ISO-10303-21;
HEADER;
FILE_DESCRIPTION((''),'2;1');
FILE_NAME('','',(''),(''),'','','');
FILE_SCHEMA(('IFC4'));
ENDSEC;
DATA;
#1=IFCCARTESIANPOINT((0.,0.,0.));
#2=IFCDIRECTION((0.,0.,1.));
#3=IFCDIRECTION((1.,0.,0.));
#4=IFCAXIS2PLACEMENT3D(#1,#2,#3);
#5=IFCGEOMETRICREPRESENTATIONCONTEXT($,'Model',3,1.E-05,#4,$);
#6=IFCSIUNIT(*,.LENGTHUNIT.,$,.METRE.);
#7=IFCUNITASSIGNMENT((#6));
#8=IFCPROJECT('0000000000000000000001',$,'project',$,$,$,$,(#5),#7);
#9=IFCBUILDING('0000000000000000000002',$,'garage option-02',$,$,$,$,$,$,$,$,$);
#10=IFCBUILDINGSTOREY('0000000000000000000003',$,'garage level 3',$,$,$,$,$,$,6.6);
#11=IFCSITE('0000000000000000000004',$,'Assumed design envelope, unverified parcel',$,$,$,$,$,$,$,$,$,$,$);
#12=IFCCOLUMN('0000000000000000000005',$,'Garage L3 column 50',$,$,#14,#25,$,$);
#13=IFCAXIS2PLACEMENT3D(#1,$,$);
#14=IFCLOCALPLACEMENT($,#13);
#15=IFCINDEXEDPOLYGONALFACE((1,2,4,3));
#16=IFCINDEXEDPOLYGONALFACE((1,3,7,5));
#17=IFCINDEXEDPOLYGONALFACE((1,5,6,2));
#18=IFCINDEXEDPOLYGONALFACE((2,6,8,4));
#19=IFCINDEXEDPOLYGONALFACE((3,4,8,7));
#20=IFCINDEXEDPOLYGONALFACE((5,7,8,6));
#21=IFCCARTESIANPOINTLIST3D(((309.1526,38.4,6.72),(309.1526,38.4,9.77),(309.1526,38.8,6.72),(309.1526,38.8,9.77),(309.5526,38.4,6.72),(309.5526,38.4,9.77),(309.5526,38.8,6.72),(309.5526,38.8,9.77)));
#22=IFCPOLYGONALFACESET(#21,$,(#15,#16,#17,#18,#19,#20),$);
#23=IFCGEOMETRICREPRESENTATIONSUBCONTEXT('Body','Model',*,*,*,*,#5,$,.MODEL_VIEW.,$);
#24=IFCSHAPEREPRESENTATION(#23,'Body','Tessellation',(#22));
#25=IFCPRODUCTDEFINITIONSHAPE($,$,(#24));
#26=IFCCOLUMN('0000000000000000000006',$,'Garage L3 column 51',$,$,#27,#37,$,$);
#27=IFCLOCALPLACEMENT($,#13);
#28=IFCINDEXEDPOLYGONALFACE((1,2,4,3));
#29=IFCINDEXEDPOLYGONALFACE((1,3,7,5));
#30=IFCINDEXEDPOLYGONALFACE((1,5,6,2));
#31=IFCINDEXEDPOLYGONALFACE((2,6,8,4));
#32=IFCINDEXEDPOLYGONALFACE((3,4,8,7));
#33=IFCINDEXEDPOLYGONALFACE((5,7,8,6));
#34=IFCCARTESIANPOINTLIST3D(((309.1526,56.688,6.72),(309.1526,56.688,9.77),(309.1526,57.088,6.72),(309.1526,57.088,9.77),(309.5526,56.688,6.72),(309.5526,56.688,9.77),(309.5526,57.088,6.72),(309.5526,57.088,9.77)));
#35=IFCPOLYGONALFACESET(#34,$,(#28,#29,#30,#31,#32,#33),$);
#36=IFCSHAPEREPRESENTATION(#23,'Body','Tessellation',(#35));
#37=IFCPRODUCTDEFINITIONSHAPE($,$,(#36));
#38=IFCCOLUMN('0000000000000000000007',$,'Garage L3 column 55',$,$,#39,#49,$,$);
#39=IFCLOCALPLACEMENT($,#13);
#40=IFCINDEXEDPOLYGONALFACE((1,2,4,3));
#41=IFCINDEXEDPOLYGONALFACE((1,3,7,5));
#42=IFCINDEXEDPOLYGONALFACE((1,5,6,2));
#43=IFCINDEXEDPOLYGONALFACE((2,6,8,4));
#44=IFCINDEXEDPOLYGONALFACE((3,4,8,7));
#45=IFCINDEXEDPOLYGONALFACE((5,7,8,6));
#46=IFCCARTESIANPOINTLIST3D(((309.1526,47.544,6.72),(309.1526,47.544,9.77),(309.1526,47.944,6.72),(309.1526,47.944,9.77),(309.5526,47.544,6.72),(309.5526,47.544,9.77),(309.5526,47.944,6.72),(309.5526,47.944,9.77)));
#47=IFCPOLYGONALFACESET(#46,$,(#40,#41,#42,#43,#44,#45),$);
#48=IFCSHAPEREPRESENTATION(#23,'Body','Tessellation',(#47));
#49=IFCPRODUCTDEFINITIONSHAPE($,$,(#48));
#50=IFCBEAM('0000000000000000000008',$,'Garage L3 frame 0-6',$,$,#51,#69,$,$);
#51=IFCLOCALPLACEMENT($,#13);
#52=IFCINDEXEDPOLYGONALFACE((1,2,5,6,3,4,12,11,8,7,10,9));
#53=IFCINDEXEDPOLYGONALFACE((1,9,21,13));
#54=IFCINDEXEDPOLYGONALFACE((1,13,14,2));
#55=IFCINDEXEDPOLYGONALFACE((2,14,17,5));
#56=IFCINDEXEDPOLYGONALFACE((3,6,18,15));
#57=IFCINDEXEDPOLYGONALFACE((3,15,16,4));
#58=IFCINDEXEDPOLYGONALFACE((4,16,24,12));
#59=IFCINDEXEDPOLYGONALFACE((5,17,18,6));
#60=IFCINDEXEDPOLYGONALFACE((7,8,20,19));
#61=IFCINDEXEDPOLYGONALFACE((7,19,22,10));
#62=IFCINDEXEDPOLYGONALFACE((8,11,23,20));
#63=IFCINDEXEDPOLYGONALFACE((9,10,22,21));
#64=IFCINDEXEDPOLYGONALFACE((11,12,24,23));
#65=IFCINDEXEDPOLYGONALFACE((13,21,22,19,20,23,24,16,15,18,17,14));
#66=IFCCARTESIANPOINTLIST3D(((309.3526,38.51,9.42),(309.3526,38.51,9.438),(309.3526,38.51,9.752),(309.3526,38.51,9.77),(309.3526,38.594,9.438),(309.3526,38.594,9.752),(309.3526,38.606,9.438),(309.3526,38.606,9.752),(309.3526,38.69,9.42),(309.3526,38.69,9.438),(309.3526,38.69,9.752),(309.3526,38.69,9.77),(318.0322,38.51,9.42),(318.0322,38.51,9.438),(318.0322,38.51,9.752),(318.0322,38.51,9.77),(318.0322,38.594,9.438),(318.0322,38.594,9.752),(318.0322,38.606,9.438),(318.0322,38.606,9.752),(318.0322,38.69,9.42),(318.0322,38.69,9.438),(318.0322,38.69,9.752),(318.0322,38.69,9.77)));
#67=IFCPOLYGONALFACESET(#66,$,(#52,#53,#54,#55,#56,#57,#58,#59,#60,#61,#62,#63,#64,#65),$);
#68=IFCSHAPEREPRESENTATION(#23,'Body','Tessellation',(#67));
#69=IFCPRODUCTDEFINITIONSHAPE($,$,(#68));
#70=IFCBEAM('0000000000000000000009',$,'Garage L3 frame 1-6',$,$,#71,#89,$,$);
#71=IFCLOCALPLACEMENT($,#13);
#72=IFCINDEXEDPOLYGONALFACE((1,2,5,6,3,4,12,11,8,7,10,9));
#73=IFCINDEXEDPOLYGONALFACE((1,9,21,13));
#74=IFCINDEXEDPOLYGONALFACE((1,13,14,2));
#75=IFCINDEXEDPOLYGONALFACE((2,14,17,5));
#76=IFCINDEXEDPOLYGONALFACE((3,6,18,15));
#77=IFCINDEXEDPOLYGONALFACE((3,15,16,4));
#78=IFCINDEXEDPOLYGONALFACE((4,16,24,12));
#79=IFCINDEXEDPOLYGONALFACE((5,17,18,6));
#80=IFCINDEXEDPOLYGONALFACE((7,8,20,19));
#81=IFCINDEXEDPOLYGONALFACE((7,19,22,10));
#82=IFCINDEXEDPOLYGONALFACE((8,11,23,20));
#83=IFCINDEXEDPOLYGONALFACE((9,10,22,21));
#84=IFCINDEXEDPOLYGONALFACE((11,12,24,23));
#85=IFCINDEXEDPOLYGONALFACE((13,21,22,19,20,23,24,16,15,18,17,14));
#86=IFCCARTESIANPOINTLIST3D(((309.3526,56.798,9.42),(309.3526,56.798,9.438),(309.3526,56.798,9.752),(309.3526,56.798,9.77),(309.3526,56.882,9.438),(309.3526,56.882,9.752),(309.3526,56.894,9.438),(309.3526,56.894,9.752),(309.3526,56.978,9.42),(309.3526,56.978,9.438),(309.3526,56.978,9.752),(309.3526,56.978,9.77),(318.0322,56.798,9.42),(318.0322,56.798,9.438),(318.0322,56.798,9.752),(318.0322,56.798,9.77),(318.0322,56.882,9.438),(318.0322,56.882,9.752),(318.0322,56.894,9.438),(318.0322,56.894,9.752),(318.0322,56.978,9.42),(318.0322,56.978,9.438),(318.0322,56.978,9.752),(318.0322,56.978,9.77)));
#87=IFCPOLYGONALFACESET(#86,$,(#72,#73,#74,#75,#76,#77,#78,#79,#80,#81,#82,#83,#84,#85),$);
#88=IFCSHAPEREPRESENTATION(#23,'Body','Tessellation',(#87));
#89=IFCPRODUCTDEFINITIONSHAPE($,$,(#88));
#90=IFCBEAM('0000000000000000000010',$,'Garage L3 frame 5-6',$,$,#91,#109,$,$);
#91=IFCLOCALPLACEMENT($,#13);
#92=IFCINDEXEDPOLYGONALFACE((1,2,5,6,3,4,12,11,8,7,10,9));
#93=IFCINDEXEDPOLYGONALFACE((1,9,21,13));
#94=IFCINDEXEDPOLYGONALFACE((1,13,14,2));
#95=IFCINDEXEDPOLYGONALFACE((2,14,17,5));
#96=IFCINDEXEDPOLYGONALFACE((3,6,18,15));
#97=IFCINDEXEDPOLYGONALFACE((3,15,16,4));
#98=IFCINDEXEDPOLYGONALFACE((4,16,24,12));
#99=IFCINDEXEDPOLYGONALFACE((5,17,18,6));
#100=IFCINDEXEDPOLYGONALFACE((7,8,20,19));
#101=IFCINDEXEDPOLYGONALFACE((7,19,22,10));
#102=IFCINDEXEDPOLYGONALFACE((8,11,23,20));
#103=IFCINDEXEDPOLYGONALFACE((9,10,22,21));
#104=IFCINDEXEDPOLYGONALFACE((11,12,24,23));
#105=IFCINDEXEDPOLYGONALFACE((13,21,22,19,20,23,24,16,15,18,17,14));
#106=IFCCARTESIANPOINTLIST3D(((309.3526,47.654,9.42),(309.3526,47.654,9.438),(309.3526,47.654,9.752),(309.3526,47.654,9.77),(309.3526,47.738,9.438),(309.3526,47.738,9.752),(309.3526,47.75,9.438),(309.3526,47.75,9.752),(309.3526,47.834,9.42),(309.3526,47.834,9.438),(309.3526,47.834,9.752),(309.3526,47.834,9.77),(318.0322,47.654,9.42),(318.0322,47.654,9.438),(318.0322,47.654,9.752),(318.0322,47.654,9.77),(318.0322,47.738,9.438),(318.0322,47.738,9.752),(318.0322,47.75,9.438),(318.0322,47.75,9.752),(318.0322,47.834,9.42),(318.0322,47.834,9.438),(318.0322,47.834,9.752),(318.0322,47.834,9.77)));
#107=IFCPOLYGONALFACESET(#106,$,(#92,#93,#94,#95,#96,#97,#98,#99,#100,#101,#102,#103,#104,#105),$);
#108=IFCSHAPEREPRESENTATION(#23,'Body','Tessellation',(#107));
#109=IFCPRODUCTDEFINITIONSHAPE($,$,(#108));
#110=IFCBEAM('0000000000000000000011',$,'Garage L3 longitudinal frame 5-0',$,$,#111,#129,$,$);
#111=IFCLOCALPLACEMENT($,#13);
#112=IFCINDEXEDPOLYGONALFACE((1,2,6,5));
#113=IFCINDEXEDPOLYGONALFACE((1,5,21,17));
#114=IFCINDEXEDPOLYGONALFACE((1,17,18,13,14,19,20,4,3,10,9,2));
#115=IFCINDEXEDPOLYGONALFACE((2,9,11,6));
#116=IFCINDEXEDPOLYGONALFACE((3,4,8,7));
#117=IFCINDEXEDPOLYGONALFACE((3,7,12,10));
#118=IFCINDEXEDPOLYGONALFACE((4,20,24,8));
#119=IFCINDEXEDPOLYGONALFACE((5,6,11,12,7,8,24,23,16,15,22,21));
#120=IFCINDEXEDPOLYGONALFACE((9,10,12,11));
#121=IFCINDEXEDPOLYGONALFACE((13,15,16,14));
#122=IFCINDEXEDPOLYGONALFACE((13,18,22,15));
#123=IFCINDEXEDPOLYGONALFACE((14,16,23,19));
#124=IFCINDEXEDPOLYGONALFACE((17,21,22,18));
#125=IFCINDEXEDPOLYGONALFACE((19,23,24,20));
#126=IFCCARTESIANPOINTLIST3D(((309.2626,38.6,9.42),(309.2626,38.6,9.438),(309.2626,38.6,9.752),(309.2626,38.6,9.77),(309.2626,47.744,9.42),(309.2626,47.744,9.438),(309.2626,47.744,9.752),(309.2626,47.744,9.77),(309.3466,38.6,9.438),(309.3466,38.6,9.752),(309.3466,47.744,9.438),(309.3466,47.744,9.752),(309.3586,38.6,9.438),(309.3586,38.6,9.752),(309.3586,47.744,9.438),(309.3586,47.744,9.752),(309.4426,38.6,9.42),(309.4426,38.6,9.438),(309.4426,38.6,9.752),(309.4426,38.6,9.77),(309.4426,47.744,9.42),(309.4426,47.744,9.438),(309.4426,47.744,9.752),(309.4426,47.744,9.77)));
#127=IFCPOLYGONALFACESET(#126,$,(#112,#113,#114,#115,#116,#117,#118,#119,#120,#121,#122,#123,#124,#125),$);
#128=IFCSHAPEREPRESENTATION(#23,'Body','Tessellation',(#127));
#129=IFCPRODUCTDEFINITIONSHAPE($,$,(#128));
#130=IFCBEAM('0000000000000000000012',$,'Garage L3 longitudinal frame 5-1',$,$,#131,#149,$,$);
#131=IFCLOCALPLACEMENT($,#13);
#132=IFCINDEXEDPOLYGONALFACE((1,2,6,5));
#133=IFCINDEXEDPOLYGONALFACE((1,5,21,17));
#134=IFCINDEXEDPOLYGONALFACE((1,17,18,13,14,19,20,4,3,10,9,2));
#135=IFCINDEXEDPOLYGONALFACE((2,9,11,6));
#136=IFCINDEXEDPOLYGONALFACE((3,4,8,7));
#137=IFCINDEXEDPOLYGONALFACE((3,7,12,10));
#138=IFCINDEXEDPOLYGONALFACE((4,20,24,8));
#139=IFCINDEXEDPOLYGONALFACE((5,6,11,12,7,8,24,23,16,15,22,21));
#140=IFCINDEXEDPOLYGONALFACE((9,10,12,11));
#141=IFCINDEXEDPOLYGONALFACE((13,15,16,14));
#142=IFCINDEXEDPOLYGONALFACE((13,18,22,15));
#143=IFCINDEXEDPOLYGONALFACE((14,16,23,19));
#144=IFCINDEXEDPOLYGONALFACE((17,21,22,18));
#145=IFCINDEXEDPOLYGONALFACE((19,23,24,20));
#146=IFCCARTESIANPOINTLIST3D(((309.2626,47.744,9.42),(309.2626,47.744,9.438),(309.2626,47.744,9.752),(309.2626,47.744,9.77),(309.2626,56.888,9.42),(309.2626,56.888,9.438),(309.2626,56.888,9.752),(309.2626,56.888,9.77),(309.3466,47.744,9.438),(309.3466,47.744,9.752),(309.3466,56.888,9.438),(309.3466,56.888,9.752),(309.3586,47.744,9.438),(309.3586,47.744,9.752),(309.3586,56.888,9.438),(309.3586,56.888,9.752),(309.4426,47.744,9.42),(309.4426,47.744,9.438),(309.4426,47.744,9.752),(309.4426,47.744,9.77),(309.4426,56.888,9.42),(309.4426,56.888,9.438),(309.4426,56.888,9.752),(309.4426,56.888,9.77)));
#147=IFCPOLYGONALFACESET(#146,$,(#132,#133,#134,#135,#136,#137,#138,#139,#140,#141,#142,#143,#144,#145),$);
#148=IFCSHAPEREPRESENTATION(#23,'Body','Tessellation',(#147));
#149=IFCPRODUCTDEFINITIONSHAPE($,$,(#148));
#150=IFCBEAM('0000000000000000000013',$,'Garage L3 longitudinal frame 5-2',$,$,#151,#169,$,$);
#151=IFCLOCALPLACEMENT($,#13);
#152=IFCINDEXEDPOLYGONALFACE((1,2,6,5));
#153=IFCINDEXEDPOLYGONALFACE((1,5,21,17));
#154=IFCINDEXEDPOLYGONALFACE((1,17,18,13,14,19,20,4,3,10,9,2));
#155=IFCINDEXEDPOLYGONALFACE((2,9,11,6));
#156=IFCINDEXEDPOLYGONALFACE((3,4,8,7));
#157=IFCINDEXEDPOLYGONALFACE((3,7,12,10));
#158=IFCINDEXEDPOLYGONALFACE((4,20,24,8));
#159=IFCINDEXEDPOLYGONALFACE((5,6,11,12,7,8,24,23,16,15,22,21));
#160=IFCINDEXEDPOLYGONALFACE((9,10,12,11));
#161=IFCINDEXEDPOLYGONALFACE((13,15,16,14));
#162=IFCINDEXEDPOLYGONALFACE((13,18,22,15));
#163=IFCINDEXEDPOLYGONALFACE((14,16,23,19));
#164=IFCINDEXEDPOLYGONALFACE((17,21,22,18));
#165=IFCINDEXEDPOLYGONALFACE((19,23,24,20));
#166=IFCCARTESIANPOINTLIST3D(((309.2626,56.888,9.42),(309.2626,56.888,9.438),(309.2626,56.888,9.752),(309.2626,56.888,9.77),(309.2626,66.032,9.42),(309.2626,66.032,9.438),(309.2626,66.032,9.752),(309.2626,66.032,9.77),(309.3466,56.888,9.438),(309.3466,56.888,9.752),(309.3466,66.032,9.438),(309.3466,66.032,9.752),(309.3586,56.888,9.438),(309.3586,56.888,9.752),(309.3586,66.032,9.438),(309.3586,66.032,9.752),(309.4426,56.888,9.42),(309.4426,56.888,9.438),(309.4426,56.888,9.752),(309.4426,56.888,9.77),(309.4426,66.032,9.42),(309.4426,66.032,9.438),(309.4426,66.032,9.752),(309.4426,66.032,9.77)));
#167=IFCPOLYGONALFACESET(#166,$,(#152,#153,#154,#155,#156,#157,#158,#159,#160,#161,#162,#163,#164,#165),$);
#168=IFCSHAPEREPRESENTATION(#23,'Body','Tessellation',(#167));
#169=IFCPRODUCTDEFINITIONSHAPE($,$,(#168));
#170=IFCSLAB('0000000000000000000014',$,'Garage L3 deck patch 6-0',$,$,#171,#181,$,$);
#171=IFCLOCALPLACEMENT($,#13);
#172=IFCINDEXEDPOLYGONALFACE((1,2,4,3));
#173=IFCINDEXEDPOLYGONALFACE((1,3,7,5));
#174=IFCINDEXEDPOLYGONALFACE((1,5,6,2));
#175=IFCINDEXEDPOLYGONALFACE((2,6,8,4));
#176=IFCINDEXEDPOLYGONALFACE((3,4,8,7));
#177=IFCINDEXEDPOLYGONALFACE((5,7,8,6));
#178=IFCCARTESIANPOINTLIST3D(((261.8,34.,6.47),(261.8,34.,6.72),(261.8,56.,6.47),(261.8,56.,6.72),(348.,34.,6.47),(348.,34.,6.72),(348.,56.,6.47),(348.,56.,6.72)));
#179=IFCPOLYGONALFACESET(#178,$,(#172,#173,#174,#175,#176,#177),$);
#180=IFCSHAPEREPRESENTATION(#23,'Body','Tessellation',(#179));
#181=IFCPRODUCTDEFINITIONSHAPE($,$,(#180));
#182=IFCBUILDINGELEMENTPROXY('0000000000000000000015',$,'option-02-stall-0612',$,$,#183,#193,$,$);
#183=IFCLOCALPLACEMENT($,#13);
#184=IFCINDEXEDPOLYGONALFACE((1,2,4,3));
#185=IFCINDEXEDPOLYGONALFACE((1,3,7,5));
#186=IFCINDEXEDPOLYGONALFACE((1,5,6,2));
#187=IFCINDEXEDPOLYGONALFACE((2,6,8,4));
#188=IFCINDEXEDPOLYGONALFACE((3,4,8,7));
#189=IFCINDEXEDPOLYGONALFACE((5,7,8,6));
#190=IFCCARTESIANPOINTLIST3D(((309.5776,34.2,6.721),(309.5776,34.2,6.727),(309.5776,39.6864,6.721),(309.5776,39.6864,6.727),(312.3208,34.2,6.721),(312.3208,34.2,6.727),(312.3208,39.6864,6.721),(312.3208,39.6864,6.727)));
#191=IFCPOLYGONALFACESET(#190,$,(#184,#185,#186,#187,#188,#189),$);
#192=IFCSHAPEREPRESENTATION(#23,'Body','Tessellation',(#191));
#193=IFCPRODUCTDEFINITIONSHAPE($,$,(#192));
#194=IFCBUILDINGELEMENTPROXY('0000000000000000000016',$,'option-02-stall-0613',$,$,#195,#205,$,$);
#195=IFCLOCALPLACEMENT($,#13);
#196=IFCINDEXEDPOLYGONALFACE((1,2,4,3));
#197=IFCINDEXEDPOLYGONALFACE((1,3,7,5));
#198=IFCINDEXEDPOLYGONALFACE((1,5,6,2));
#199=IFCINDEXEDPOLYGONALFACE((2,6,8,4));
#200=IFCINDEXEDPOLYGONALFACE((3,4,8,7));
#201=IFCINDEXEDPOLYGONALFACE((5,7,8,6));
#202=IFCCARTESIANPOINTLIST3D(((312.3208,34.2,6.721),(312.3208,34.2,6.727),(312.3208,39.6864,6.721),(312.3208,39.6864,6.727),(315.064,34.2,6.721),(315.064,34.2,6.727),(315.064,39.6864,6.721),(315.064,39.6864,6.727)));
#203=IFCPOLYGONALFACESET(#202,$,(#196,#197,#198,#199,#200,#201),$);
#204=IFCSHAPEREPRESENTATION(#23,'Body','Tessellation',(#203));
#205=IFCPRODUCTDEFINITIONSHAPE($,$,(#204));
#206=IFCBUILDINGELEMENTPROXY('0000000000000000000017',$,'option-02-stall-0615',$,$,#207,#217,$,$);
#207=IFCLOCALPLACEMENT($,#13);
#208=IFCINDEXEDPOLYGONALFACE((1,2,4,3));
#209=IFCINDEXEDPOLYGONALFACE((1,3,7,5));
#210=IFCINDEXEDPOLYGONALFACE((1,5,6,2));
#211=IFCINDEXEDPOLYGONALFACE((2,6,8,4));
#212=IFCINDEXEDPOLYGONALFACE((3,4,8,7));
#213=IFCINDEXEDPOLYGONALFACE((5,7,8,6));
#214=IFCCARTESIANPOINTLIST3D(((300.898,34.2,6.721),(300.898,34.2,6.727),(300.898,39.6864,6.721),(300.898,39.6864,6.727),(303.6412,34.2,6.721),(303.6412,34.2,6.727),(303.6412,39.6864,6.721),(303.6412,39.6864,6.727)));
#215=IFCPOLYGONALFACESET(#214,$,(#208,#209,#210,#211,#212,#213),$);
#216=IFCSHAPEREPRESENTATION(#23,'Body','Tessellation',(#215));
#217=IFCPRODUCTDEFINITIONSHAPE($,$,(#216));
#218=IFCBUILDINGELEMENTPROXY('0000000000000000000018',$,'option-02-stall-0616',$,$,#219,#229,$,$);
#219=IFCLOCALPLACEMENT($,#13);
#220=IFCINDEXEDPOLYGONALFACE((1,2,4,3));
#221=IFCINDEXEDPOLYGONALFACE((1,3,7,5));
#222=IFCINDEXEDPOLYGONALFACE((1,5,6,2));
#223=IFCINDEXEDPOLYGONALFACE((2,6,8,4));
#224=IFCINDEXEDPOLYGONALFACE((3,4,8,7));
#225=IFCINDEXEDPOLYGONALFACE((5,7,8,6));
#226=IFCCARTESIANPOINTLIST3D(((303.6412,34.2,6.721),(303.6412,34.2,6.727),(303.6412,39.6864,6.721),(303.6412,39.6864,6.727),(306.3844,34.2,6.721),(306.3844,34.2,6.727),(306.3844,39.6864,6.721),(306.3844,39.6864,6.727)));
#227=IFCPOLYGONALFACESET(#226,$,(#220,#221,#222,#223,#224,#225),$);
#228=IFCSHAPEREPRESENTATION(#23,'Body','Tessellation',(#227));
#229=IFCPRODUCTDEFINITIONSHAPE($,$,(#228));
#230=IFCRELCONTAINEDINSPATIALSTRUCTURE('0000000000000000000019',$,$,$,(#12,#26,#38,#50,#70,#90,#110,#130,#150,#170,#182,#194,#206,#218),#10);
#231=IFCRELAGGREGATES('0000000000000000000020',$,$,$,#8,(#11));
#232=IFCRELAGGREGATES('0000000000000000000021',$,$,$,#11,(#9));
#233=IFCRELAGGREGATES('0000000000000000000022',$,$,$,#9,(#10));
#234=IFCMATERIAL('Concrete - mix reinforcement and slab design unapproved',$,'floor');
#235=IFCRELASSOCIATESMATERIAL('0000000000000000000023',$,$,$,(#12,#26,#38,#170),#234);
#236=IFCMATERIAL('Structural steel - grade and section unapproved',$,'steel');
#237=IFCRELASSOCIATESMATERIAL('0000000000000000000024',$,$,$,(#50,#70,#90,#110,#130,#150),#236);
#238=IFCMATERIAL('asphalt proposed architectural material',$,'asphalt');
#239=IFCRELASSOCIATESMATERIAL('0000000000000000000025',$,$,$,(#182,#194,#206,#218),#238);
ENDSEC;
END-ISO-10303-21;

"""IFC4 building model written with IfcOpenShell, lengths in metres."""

from ifc_helpers import new_model, si_unit, frame, origin_with_axes, place, context, subcontext, project, spatial, rectangle, i_section, extrude, material, element, save


model = new_model("IFC4")

# Units and contexts
model_context = context("Model", 3, precision=1e-05, world=origin_with_axes())
body_context = subcontext(model_context, "Body", "Model", "MODEL_VIEW")
ifc_project = project(units=[si_unit("LENGTHUNIT", "METRE")], contexts=[model_context])

# Site, building, storey
site = spatial("IfcSite", under=ifc_project, Name="Assumed design envelope, unverified parcel")
building = spatial("IfcBuilding", under=site, Name="garage option-02")
storey = spatial("IfcBuildingStorey", under=building, Name="garage level 3", Elevation=6.6)

# Columns
ifc_material_1 = material(Name="Concrete - mix reinforcement and slab design unapproved", Category="floor")
for number, where, z_axis, x_axis, name in (
    (1, (309.3526, 38.6, 6.72), (0.0, 0.0, 1.0), (1.0, 0.0, 0.0), "Garage L3 column 50"),
    (2, (309.3526, 56.888, 6.72), (0.0, 0.0, 1.0), (1.0, 0.0, 0.0), "Garage L3 column 51"),
    (3, (309.3526, 47.744, 6.72), (0.0, 0.0, 1.0), (1.0, 0.0, 0.0), "Garage L3 column 55"),
):
    element("IfcColumn", number, at=place(None, frame(where, z_axis=z_axis, x_axis=x_axis)), inside=storey, material=ifc_material_1, Name=name, context=body_context, shape_type="SweptSolid", body=[
        extrude(rectangle(XDim=0.4, YDim=0.4), origin_with_axes(), (0.0, 0.0, 1.0), 3.05),
    ])

# Beams
ifc_material_2 = material(Name="Structural steel - grade and section unapproved", Category="steel")
for number, where, z_axis, x_axis, name in (
    (4, (309.3526, 38.6, 9.595), (1.0, 0.0, 0.0), (0.0, 1.0, 0.0), "Garage L3 frame 0-6"),
    (5, (309.3526, 56.888, 9.595), (1.0, 0.0, 0.0), (0.0, 1.0, 0.0), "Garage L3 frame 1-6"),
    (6, (309.3526, 47.744, 9.595), (1.0, 0.0, 0.0), (0.0, 1.0, 0.0), "Garage L3 frame 5-6"),
):
    element("IfcBeam", number, at=place(None, frame(where, z_axis=z_axis, x_axis=x_axis)), inside=storey, material=ifc_material_2, Name=name, context=body_context, shape_type="SweptSolid", body=[
        extrude(i_section(OverallWidth=0.18, OverallDepth=0.35, WebThickness=0.012, FlangeThickness=0.018, FilletRadius=0.0), origin_with_axes(), (0.0, 0.0, 1.0), 8.6796),
    ])
for number, where, z_axis, x_axis, name in (
    (7, (309.3526, 38.6, 9.595), (0.0, 1.0, 0.0), (-1.0, 0.0, 0.0), "Garage L3 longitudinal frame 5-0"),
    (8, (309.3526, 47.744, 9.595), (0.0, 1.0, 0.0), (-1.0, 0.0, 0.0), "Garage L3 longitudinal frame 5-1"),
):
    element("IfcBeam", number, at=place(None, frame(where, z_axis=z_axis, x_axis=x_axis)), inside=storey, material=ifc_material_2, Name=name, context=body_context, shape_type="SweptSolid", body=[
        extrude(i_section(OverallWidth=0.18, OverallDepth=0.35, WebThickness=0.012, FlangeThickness=0.018, FilletRadius=0.0), origin_with_axes(), (0.0, 0.0, 1.0), 9.144),
    ])
beam_placement = place(None, frame((309.3526, 56.888, 9.595), z_axis=(0.0, 1.0, 0.0), x_axis=(-1.0, 0.0, 0.0)))
element("IfcBeam", 9, at=beam_placement, inside=storey, material=ifc_material_2, Name="Garage L3 longitudinal frame 5-2", context=body_context, shape_type="SweptSolid", body=[
    extrude(i_section(OverallWidth=0.18, OverallDepth=0.35, WebThickness=0.012, FlangeThickness=0.018, FilletRadius=0.0), origin_with_axes(), (0.0, 0.0, 1.0), 9.144),
])

# Slab
slab_placement = place(None, frame((304.9, 45.0, 6.47), z_axis=(0.0, 0.0, 1.0), x_axis=(1.0, 0.0, 0.0)))
element("IfcSlab", 10, at=slab_placement, inside=storey, material=ifc_material_1, Name="Garage L3 deck patch 6-0", context=body_context, shape_type="SweptSolid", body=[
    extrude(rectangle(XDim=86.2, YDim=22.0), origin_with_axes(), (0.0, 0.0, 1.0), 0.25),
])

# Building element proxies
ifc_material_3 = material(Name="asphalt proposed architectural material", Category="asphalt")
for number, where, z_axis, x_axis, name in (
    (11, (310.9492, 36.9432, 6.721), (0.0, 0.0, 1.0), (1.0, 0.0, 0.0), "option-02-stall-0612"),
    (12, (313.6924, 36.9432, 6.721), (0.0, 0.0, 1.0), (1.0, 0.0, 0.0), "option-02-stall-0613"),
    (13, (302.2696, 36.9432, 6.721), (0.0, 0.0, 1.0), (1.0, 0.0, 0.0), "option-02-stall-0615"),
    (14, (305.0128, 36.9432, 6.721), (0.0, 0.0, 1.0), (1.0, 0.0, 0.0), "option-02-stall-0616"),
):
    element("IfcBuildingElementProxy", number, at=place(None, frame(where, z_axis=z_axis, x_axis=x_axis)), inside=storey, material=ifc_material_3, Name=name, context=body_context, shape_type="SweptSolid", body=[
        extrude(rectangle(XDim=2.7432, YDim=5.4864), origin_with_axes(), (0.0, 0.0, 1.0), 0.006),
    ])

save(model, "model.ifc")
